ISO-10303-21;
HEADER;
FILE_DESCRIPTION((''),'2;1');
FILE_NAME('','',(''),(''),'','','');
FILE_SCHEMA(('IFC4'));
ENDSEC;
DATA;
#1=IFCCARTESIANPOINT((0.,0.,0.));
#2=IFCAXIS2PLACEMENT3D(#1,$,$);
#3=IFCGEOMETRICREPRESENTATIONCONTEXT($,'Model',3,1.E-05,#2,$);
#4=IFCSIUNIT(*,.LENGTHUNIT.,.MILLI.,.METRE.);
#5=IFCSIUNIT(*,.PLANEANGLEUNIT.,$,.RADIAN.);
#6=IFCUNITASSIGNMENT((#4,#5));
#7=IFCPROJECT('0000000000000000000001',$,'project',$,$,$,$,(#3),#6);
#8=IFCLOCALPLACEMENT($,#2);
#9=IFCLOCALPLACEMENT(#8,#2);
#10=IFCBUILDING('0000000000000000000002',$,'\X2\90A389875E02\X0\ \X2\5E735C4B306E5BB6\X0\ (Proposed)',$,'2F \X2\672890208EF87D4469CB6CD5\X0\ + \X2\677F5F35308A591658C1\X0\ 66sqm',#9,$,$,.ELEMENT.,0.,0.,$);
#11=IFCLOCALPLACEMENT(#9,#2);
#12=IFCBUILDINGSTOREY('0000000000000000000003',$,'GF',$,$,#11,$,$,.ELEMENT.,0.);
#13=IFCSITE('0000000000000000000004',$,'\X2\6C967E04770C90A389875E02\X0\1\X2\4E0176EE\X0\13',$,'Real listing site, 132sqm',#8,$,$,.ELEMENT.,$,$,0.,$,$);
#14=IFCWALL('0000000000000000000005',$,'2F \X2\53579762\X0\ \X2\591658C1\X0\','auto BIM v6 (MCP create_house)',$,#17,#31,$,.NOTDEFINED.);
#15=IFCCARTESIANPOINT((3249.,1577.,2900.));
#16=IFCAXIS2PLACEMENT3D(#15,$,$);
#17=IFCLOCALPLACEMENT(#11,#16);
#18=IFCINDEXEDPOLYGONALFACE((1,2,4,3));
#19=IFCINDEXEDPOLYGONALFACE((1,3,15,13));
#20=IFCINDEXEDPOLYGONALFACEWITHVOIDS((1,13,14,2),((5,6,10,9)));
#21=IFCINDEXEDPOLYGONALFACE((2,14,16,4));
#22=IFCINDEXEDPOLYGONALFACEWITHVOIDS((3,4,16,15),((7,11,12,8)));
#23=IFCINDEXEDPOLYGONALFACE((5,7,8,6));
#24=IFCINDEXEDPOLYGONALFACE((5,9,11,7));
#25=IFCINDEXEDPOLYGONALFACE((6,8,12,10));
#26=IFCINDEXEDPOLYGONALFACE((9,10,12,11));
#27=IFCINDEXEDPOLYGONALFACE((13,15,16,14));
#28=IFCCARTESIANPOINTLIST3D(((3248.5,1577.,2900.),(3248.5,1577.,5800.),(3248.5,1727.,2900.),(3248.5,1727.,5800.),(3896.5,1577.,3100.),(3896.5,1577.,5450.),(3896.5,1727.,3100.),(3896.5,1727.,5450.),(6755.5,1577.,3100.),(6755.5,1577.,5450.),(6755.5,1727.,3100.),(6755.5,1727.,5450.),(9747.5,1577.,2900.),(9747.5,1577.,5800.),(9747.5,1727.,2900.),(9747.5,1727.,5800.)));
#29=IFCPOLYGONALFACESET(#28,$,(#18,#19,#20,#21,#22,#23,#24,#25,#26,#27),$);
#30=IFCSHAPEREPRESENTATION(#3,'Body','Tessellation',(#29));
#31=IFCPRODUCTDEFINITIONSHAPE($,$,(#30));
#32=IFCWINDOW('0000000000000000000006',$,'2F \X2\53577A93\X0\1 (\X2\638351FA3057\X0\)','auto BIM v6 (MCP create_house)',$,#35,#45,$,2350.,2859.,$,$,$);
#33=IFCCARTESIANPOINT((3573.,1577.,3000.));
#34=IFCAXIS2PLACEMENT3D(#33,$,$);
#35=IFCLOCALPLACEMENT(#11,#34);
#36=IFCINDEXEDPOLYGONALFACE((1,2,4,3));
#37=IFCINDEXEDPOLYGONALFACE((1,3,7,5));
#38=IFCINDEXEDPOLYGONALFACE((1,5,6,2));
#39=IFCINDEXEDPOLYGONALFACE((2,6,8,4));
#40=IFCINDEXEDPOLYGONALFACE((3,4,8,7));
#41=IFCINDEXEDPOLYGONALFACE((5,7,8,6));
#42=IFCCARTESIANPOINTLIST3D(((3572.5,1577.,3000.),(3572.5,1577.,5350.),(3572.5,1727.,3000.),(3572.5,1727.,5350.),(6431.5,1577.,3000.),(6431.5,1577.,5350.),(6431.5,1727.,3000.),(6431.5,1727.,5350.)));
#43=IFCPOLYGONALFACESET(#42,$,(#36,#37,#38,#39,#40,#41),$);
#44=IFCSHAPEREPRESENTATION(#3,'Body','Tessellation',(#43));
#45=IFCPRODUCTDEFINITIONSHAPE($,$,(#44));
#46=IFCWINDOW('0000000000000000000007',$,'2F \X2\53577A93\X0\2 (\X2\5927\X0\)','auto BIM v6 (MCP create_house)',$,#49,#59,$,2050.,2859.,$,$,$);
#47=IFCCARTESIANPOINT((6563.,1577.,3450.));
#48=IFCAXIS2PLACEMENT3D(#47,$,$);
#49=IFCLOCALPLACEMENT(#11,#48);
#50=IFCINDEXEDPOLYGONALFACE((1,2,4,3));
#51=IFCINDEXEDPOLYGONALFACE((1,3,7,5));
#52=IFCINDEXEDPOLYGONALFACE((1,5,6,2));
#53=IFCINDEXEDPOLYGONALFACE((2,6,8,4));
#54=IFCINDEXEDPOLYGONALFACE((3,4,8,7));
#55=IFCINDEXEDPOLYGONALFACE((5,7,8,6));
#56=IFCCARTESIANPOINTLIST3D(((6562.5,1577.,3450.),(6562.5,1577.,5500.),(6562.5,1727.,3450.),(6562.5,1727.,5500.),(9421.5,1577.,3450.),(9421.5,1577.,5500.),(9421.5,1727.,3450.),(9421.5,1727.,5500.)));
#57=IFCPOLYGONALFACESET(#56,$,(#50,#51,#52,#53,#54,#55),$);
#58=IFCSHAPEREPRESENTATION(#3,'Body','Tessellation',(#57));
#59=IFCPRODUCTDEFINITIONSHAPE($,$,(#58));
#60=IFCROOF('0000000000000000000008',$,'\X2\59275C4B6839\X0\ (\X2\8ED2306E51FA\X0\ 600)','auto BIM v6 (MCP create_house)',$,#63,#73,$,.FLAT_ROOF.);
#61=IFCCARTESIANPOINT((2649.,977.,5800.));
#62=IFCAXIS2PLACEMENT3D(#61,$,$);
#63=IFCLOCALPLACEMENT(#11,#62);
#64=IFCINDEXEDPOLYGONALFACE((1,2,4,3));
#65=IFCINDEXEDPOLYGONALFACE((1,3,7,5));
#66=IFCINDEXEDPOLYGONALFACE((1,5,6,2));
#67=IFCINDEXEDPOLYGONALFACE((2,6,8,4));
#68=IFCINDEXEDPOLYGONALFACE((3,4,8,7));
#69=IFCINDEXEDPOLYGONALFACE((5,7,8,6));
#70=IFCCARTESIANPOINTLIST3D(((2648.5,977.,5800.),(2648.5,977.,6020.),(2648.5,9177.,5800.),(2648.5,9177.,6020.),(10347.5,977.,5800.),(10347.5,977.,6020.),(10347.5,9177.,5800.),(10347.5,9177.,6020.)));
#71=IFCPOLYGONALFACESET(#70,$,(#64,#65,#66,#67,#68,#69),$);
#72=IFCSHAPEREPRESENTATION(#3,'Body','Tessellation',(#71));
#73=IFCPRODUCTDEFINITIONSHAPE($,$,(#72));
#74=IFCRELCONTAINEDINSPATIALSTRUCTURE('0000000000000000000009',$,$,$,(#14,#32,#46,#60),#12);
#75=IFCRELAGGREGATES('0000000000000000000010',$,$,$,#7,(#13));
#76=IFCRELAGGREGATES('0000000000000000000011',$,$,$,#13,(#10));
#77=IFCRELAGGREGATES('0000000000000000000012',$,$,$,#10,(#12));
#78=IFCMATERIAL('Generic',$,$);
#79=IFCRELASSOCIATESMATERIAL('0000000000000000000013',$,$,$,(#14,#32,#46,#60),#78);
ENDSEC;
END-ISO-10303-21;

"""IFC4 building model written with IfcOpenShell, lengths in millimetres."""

from ifc_helpers import new_model, si_unit, frame, frame_2d, origin, place, context, project, spatial, rectangle, extrude, material, element, fill, save


model = new_model("IFC4")

# Units and contexts
model_context = context("Model", 3, precision=1e-05, world=origin())
ifc_project = project(units=[si_unit("LENGTHUNIT", "METRE", prefix="MILLI"), si_unit("PLANEANGLEUNIT", "RADIAN")], contexts=[model_context])

# Site, building, storey
site_placement = place(None, origin())
site = spatial("IfcSite", under=ifc_project, at=site_placement, Name="沖縄県那覇市1丁目13", ObjectType="Real listing site, 132sqm", CompositionType="ELEMENT", RefElevation=0.0)
building_placement = place(site_placement, origin())
building = spatial("IfcBuilding", under=site, at=building_placement, Name="那覇市 平屋の家 (Proposed)", ObjectType="2F 木造軸組構法 + 板張り外壁 66sqm", CompositionType="ELEMENT", ElevationOfRefHeight=0.0, ElevationOfTerrain=0.0)
storey_placement = place(building_placement, origin())
storey = spatial("IfcBuildingStorey", under=building, at=storey_placement, Name="GF", CompositionType="ELEMENT", Elevation=0.0)

# Shared definitions
ifc_material = material(Name="Generic")

# Wall, openings, windows
wall_1_placement = place(storey_placement, frame((3249.0, 1577.0, 2900.0)))
wall_1 = element("IfcWall", 1, at=wall_1_placement, inside=storey, material=ifc_material, Name="2F 南面 外壁", Description="auto BIM v6 (MCP create_house)", PredefinedType="NOTDEFINED", context=model_context, shape_type="SweptSolid", body=[
    extrude(rectangle(XDim=6499.0, YDim=150.0, at=frame_2d((3249.0, 75.0))), frame((3249.0, 1577.0, 2900.0)), (0.0, 0.0, 1.0), 2900.0),
])
opening_1_placement = place(storey_placement, frame((3573.0, 1577.0, 3000.0)))
opening_1 = element("IfcOpeningElement", 2, at=opening_1_placement, cuts=wall_1, PredefinedType="NOTDEFINED", context=model_context, shape_type="SweptSolid", body=[
    extrude(rectangle(XDim=2859.0, YDim=150.0, at=frame_2d((1429.0, 75.0))), frame((3573.0, 1577.0, 3000.0)), (0.0, 0.0, 1.0), 2350.0),
])
opening_2_placement = place(storey_placement, frame((6563.0, 1577.0, 3450.0)))
opening_2 = element("IfcOpeningElement", 3, at=opening_2_placement, cuts=wall_1, PredefinedType="NOTDEFINED", context=model_context, shape_type="SweptSolid", body=[
    extrude(rectangle(XDim=2859.0, YDim=150.0, at=frame_2d((1429.0, 75.0))), frame((6563.0, 1577.0, 3450.0)), (0.0, 0.0, 1.0), 2050.0),
])
window_1_placement = place(storey_placement, frame((3573.0, 1577.0, 3000.0)))
window_1 = element("IfcWindow", 4, at=window_1_placement, inside=storey, material=ifc_material, Name="2F 南窓1 (掃出し)", Description="auto BIM v6 (MCP create_house)", OverallHeight=2350.0, OverallWidth=2859.0, context=model_context, shape_type="SweptSolid", body=[
    extrude(rectangle(XDim=2859.0, YDim=150.0, at=frame_2d((1429.0, 75.0))), frame((3573.0, 1577.0, 3000.0)), (0.0, 0.0, 1.0), 2350.0),
])
fill(opening_1, window_1)
window_2_placement = place(storey_placement, frame((6563.0, 1577.0, 3450.0)))
window_2 = element("IfcWindow", 5, at=window_2_placement, inside=storey, material=ifc_material, Name="2F 南窓2 (大)", Description="auto BIM v6 (MCP create_house)", OverallHeight=2050.0, OverallWidth=2859.0, context=model_context, shape_type="SweptSolid", body=[
    extrude(rectangle(XDim=2859.0, YDim=150.0, at=frame_2d((1429.0, 75.0))), frame((6563.0, 1577.0, 3450.0)), (0.0, 0.0, 1.0), 2050.0),
])
fill(opening_2, window_2)

# Roof
roof_placement = place(storey_placement, frame((2649.0, 977.0, 5800.0)))
element("IfcRoof", 6, at=roof_placement, inside=storey, material=ifc_material, Name="大屋根 (軒の出 600)", Description="auto BIM v6 (MCP create_house)", PredefinedType="FLAT_ROOF", context=model_context, shape_type="SweptSolid", body=[
    extrude(rectangle(XDim=7699.0, YDim=8200.0, at=frame_2d((3849.0, 4100.0))), frame((2649.0, 977.0, 5800.0)), (0.0, 0.0, 1.0), 220.0),
])

save(model, "model.ifc")
